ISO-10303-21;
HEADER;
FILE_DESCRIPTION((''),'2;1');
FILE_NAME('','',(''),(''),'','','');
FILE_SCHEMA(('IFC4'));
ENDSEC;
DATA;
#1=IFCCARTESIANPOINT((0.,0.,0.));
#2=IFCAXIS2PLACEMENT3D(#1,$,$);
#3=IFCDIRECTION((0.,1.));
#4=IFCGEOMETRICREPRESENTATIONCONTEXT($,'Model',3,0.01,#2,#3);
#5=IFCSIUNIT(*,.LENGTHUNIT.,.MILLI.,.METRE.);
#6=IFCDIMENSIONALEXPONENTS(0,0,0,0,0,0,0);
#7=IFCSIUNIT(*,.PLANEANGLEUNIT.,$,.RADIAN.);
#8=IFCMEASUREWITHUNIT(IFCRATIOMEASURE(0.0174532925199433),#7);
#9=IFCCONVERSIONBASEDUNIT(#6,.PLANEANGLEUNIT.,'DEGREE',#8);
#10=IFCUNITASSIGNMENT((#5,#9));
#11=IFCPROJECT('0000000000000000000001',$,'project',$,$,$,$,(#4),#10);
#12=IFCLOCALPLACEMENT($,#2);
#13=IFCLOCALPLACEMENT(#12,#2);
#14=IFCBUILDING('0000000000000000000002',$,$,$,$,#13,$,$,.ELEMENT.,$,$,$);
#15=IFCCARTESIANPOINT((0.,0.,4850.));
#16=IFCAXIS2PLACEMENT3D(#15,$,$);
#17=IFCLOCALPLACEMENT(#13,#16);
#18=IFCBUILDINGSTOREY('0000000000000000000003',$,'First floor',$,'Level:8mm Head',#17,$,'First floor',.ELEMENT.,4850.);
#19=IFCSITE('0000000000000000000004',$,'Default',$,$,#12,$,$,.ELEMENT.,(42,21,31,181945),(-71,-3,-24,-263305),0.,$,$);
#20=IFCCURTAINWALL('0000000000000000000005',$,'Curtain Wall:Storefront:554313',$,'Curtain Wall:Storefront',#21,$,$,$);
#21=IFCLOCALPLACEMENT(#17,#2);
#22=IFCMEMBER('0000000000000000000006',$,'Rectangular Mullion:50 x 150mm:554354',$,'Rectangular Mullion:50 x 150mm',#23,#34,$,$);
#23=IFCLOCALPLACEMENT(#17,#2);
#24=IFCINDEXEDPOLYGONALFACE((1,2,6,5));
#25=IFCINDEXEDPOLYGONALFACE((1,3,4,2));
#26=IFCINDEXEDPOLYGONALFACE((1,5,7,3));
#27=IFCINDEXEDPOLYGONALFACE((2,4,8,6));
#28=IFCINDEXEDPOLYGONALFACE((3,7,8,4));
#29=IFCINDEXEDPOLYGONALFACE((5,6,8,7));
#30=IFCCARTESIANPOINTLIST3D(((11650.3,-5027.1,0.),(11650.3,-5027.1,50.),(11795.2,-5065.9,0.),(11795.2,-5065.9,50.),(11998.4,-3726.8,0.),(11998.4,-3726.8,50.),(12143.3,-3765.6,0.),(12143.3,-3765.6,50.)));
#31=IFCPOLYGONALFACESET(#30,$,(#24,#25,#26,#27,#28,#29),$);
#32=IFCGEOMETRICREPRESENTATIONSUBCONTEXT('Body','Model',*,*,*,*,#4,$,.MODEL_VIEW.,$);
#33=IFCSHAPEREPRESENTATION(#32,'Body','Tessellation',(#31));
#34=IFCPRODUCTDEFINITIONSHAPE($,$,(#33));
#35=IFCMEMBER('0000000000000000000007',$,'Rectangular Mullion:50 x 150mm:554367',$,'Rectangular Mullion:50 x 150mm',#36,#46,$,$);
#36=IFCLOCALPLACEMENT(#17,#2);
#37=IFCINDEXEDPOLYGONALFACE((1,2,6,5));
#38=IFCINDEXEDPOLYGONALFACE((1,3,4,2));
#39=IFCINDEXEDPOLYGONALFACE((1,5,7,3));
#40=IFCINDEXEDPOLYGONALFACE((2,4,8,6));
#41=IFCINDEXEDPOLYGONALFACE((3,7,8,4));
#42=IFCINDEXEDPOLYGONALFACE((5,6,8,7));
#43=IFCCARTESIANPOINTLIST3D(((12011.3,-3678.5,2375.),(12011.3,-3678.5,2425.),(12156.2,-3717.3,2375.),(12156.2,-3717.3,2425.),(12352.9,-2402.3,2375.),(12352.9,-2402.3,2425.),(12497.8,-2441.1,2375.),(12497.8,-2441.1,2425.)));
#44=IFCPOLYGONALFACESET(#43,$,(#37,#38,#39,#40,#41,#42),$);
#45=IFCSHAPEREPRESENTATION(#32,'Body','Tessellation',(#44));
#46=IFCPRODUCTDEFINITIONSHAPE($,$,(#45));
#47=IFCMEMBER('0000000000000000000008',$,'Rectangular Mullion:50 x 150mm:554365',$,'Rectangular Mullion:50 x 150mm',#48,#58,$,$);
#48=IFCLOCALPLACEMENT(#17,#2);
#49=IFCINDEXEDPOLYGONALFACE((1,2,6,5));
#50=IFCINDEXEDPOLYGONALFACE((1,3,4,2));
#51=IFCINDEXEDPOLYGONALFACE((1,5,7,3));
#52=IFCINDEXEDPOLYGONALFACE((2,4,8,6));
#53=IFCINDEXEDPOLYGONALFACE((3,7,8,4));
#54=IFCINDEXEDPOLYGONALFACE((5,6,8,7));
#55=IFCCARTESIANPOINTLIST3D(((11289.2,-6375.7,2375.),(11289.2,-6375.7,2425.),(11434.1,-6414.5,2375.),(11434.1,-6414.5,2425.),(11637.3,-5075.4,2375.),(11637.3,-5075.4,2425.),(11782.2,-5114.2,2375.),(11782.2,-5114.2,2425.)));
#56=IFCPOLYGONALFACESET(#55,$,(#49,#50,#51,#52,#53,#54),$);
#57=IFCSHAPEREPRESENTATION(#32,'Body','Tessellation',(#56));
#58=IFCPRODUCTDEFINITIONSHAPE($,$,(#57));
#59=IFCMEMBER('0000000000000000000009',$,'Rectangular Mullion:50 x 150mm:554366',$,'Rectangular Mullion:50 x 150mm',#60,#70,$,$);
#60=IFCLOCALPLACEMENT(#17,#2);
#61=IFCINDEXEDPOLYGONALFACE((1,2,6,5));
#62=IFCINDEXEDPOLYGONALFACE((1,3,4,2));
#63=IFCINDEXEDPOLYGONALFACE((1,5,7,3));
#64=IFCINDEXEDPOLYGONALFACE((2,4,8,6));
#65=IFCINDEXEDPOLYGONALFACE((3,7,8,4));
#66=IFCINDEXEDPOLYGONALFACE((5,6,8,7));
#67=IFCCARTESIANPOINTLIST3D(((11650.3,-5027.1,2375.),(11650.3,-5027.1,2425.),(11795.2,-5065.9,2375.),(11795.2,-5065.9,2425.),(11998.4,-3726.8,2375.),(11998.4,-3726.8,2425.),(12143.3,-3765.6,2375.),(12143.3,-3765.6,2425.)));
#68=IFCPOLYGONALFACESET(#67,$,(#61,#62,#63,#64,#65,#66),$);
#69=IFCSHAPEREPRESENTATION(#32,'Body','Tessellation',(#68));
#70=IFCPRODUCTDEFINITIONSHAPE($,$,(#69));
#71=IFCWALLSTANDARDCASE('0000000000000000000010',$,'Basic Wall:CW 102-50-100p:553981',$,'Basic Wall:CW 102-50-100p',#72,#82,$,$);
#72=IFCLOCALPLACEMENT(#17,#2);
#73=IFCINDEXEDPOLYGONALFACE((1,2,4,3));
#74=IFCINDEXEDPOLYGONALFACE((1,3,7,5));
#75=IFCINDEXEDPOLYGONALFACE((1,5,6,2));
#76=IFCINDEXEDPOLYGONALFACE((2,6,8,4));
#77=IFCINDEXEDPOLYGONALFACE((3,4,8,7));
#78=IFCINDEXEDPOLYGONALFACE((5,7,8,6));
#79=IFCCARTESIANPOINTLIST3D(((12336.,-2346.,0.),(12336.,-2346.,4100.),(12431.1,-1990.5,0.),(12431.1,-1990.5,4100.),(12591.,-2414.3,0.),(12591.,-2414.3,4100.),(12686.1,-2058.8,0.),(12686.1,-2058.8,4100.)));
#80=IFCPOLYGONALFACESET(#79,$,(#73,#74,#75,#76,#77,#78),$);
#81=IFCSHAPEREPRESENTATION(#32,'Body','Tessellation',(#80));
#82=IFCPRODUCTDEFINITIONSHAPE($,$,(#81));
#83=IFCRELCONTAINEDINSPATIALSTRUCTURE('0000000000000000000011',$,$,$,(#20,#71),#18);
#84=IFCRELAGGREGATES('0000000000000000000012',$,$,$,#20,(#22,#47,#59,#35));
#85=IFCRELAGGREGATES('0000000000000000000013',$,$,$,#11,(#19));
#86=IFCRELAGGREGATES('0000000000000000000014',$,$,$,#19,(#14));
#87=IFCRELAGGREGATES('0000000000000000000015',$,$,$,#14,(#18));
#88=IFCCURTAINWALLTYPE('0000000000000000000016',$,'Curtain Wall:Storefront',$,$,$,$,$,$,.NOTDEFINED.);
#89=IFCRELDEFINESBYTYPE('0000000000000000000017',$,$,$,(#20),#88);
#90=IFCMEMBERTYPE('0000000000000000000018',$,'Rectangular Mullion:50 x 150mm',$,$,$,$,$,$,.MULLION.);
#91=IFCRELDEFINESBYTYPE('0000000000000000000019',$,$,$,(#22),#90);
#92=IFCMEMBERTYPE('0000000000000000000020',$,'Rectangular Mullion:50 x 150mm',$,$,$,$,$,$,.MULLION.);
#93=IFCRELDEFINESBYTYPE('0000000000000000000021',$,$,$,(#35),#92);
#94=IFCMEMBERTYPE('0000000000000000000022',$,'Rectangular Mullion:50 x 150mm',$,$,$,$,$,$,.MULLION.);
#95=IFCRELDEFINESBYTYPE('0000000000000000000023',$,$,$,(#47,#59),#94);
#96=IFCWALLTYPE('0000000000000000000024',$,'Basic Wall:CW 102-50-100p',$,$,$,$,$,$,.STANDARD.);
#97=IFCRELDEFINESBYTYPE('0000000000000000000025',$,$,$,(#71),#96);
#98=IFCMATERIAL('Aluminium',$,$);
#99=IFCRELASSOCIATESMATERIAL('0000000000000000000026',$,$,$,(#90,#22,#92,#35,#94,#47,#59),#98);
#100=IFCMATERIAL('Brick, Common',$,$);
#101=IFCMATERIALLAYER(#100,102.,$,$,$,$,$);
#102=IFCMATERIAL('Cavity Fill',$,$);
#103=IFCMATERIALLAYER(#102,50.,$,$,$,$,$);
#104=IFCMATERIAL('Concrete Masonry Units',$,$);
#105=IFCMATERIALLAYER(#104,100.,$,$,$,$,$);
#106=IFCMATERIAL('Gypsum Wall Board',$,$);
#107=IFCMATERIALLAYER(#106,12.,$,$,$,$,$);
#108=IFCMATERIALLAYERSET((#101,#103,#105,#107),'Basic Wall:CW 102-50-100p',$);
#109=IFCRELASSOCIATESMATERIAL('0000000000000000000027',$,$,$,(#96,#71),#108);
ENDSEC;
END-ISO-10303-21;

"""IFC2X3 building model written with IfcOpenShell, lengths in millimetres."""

from ifc_helpers import new_model, entity, si_unit, converted_unit, direction, frame, frame_2d, origin, origin_2d_with_axis, place, context, subcontext, project, spatial, rectangle, extrude, source, transform, mapped, material, layer, layer_set, layer_usage, type_object, type_shapes, element, aggregate, save


model = new_model("IFC2X3")

# Units and contexts
model_context = context("Model", 3, precision=0.01, world=origin(), true_north=direction((0.0, 1.0)))
body_context = subcontext(model_context, "Body", "Model", "MODEL_VIEW")
ifc_project = project(units=[si_unit("LENGTHUNIT", "METRE", prefix="MILLI"), converted_unit("PLANEANGLEUNIT", "DEGREE", entity("IfcRatioMeasure", 0.0174532925199433), si_unit("PLANEANGLEUNIT", "RADIAN"), dimensions=[0, 0, 0, 0, 0, 0, 0])], contexts=[model_context])

# Site, building, storey
site_placement = place(None, origin())
site = spatial("IfcSite", under=ifc_project, at=site_placement, Name="Default", CompositionType="ELEMENT", RefLatitude=(42, 21, 31, 181945), RefLongitude=(-71, -3, -24, -263305), RefElevation=0.0)
building_placement = place(site_placement, origin())
building = spatial("IfcBuilding", under=site, at=building_placement, CompositionType="ELEMENT")
storey_placement = place(building_placement, frame((0.0, 0.0, 4850.0)))
storey = spatial("IfcBuildingStorey", under=building, at=storey_placement, Name="First floor", ObjectType="Level:8mm Head", LongName="First floor", CompositionType="ELEMENT", Elevation=4850.0)

# Shared definitions
curtain_wall_type = type_object("IfcCurtainWallType", Name="Curtain Wall:Storefront", PredefinedType="NOTDEFINED")
ifc_material_1 = material(Name="Aluminium")

# Curtain wall
curtain_wall_1_placement = place(storey_placement, frame((0.0, 0.0, -4850.0)))
curtain_wall_1 = element("IfcCurtainWall", 1, at=curtain_wall_1_placement, inside=storey, type_object=curtain_wall_type, Name="Curtain Wall:Storefront:554313", ObjectType="Curtain Wall:Storefront")

# Members
member_type_1 = type_object("IfcMemberType", Name="Rectangular Mullion:50 x 150mm", PredefinedType="MULLION", material=ifc_material_1)
shared_shape_1 = source(origin(), body_context, "Body", "SweptSolid", [
    extrude(rectangle(XDim=150.0, YDim=50.0, at=origin_2d_with_axis()), frame((-25.0, 0.0, -1346.1), z_axis=(0.0, 0.0, 1.0), x_axis=(0.0, -1.0, 0.0)), (0.0, 0.0, 1.0), 1346.1),
])
type_shapes(member_type_1, [shared_shape_1])
member_1_placement = place(storey_placement, frame((11722.7, -5046.5, 0.0), z_axis=(-0.258607, -0.965983, 0.0), x_axis=(0.0, 0.0, -1.0)))
member_1 = element("IfcMember", 2, at=member_1_placement, type_object=member_type_1, material=ifc_material_1, Name="Rectangular Mullion:50 x 150mm:554354", ObjectType="Rectangular Mullion:50 x 150mm", context=body_context, shape_type="MappedRepresentation", body=[
    mapped(shared_shape_1, transform((0.0, 0.0, 0.0), scale=1.0)),
])
member_type_2 = type_object("IfcMemberType", Name="Rectangular Mullion:50 x 150mm", PredefinedType="MULLION", material=ifc_material_1)
shared_shape_2 = source(origin(), body_context, "Body", "SweptSolid", [
    extrude(rectangle(XDim=150.0, YDim=50.0, at=origin_2d_with_axis()), frame((0.0, 0.0, -1321.1), z_axis=(0.0, 0.0, 1.0), x_axis=(0.0, -1.0, 0.0)), (0.0, 0.0, 1.0), 1321.1),
])
type_shapes(member_type_2, [shared_shape_2])
member_2_placement = place(storey_placement, frame((12425.4, -2421.7, 2400.0), z_axis=(0.258607, 0.965983, 0.0), x_axis=(0.0, 0.0, 1.0)))
member_2 = element("IfcMember", 3, at=member_2_placement, type_object=member_type_2, material=ifc_material_1, Name="Rectangular Mullion:50 x 150mm:554367", ObjectType="Rectangular Mullion:50 x 150mm", context=body_context, shape_type="MappedRepresentation", body=[
    mapped(shared_shape_2, transform((0.0, 0.0, 0.0), scale=1.0)),
])
member_type_3 = type_object("IfcMemberType", Name="Rectangular Mullion:50 x 150mm", PredefinedType="MULLION", material=ifc_material_1)
shared_shape_3 = source(origin(), body_context, "Body", "SweptSolid", [
    extrude(rectangle(XDim=150.0, YDim=50.0, at=origin_2d_with_axis()), frame((0.0, 0.0, -1346.1), z_axis=(0.0, 0.0, 1.0), x_axis=(0.0, -1.0, 0.0)), (0.0, 0.0, 1.0), 1346.1),
])
type_shapes(member_type_3, [shared_shape_3])
member_3_placement = place(storey_placement, frame((11709.8, -5094.8, 2400.0), z_axis=(0.258607, 0.965983, 0.0), x_axis=(0.0, 0.0, 1.0)))
member_3 = element("IfcMember", 4, at=member_3_placement, type_object=member_type_3, material=ifc_material_1, Name="Rectangular Mullion:50 x 150mm:554365", ObjectType="Rectangular Mullion:50 x 150mm", context=body_context, shape_type="MappedRepresentation", body=[
    mapped(shared_shape_3, transform((0.0, 0.0, 0.0), scale=1.0)),
])
member_4_placement = place(storey_placement, frame((12070.8, -3746.2, 2400.0), z_axis=(0.258607, 0.965983, 0.0), x_axis=(0.0, 0.0, 1.0)))
member_4 = element("IfcMember", 5, at=member_4_placement, type_object=member_type_3, material=ifc_material_1, Name="Rectangular Mullion:50 x 150mm:554366", ObjectType="Rectangular Mullion:50 x 150mm", context=body_context, shape_type="MappedRepresentation", body=[
    mapped(shared_shape_3, transform((0.0, 0.0, 0.0), scale=1.0)),
])

aggregate(curtain_wall_1, [member_1, member_3, member_4, member_2])

# Wall
ifc_material_2 = material(Name="Brick, Common")
ifc_layer_1 = layer(ifc_material_2, 102.0)
ifc_material_3 = material(Name="Cavity Fill")
ifc_layer_2 = layer(ifc_material_3, 50.0)
ifc_material_4 = material(Name="Concrete Masonry Units")
ifc_layer_3 = layer(ifc_material_4, 100.0)
ifc_material_5 = material(Name="Gypsum Wall Board")
ifc_layer_4 = layer(ifc_material_5, 12.0)
ifc_layer_set = layer_set([ifc_layer_1, ifc_layer_2, ifc_layer_3, ifc_layer_4], Name="Basic Wall:CW 102-50-100p")
ifc_layer_usage = layer_usage(ifc_layer_set, "AXIS2", "POSITIVE", -132.0)
wall_type = type_object("IfcWallType", Name="Basic Wall:CW 102-50-100p", PredefinedType="STANDARD", material=ifc_layer_set)
wall_placement = place(storey_placement, frame((12463.5, -2380.2, 0.0), z_axis=(0.0, 0.0, 1.0), x_axis=(0.258607, 0.965983, 0.0)))
element("IfcWallStandardCase", 6, at=wall_placement, inside=storey, type_object=wall_type, material=ifc_layer_usage, Name="Basic Wall:CW 102-50-100p:553981", ObjectType="Basic Wall:CW 102-50-100p", context=body_context, shape_type="SweptSolid", body=[
    extrude(rectangle(XDim=368.0, YDim=264.0, at=frame_2d((184.0, 0.0), x_axis=(-1.0, 0.0))), origin(), (0.0, 0.0, 1.0), 4100.0),
])

save(model, "model.ifc")
